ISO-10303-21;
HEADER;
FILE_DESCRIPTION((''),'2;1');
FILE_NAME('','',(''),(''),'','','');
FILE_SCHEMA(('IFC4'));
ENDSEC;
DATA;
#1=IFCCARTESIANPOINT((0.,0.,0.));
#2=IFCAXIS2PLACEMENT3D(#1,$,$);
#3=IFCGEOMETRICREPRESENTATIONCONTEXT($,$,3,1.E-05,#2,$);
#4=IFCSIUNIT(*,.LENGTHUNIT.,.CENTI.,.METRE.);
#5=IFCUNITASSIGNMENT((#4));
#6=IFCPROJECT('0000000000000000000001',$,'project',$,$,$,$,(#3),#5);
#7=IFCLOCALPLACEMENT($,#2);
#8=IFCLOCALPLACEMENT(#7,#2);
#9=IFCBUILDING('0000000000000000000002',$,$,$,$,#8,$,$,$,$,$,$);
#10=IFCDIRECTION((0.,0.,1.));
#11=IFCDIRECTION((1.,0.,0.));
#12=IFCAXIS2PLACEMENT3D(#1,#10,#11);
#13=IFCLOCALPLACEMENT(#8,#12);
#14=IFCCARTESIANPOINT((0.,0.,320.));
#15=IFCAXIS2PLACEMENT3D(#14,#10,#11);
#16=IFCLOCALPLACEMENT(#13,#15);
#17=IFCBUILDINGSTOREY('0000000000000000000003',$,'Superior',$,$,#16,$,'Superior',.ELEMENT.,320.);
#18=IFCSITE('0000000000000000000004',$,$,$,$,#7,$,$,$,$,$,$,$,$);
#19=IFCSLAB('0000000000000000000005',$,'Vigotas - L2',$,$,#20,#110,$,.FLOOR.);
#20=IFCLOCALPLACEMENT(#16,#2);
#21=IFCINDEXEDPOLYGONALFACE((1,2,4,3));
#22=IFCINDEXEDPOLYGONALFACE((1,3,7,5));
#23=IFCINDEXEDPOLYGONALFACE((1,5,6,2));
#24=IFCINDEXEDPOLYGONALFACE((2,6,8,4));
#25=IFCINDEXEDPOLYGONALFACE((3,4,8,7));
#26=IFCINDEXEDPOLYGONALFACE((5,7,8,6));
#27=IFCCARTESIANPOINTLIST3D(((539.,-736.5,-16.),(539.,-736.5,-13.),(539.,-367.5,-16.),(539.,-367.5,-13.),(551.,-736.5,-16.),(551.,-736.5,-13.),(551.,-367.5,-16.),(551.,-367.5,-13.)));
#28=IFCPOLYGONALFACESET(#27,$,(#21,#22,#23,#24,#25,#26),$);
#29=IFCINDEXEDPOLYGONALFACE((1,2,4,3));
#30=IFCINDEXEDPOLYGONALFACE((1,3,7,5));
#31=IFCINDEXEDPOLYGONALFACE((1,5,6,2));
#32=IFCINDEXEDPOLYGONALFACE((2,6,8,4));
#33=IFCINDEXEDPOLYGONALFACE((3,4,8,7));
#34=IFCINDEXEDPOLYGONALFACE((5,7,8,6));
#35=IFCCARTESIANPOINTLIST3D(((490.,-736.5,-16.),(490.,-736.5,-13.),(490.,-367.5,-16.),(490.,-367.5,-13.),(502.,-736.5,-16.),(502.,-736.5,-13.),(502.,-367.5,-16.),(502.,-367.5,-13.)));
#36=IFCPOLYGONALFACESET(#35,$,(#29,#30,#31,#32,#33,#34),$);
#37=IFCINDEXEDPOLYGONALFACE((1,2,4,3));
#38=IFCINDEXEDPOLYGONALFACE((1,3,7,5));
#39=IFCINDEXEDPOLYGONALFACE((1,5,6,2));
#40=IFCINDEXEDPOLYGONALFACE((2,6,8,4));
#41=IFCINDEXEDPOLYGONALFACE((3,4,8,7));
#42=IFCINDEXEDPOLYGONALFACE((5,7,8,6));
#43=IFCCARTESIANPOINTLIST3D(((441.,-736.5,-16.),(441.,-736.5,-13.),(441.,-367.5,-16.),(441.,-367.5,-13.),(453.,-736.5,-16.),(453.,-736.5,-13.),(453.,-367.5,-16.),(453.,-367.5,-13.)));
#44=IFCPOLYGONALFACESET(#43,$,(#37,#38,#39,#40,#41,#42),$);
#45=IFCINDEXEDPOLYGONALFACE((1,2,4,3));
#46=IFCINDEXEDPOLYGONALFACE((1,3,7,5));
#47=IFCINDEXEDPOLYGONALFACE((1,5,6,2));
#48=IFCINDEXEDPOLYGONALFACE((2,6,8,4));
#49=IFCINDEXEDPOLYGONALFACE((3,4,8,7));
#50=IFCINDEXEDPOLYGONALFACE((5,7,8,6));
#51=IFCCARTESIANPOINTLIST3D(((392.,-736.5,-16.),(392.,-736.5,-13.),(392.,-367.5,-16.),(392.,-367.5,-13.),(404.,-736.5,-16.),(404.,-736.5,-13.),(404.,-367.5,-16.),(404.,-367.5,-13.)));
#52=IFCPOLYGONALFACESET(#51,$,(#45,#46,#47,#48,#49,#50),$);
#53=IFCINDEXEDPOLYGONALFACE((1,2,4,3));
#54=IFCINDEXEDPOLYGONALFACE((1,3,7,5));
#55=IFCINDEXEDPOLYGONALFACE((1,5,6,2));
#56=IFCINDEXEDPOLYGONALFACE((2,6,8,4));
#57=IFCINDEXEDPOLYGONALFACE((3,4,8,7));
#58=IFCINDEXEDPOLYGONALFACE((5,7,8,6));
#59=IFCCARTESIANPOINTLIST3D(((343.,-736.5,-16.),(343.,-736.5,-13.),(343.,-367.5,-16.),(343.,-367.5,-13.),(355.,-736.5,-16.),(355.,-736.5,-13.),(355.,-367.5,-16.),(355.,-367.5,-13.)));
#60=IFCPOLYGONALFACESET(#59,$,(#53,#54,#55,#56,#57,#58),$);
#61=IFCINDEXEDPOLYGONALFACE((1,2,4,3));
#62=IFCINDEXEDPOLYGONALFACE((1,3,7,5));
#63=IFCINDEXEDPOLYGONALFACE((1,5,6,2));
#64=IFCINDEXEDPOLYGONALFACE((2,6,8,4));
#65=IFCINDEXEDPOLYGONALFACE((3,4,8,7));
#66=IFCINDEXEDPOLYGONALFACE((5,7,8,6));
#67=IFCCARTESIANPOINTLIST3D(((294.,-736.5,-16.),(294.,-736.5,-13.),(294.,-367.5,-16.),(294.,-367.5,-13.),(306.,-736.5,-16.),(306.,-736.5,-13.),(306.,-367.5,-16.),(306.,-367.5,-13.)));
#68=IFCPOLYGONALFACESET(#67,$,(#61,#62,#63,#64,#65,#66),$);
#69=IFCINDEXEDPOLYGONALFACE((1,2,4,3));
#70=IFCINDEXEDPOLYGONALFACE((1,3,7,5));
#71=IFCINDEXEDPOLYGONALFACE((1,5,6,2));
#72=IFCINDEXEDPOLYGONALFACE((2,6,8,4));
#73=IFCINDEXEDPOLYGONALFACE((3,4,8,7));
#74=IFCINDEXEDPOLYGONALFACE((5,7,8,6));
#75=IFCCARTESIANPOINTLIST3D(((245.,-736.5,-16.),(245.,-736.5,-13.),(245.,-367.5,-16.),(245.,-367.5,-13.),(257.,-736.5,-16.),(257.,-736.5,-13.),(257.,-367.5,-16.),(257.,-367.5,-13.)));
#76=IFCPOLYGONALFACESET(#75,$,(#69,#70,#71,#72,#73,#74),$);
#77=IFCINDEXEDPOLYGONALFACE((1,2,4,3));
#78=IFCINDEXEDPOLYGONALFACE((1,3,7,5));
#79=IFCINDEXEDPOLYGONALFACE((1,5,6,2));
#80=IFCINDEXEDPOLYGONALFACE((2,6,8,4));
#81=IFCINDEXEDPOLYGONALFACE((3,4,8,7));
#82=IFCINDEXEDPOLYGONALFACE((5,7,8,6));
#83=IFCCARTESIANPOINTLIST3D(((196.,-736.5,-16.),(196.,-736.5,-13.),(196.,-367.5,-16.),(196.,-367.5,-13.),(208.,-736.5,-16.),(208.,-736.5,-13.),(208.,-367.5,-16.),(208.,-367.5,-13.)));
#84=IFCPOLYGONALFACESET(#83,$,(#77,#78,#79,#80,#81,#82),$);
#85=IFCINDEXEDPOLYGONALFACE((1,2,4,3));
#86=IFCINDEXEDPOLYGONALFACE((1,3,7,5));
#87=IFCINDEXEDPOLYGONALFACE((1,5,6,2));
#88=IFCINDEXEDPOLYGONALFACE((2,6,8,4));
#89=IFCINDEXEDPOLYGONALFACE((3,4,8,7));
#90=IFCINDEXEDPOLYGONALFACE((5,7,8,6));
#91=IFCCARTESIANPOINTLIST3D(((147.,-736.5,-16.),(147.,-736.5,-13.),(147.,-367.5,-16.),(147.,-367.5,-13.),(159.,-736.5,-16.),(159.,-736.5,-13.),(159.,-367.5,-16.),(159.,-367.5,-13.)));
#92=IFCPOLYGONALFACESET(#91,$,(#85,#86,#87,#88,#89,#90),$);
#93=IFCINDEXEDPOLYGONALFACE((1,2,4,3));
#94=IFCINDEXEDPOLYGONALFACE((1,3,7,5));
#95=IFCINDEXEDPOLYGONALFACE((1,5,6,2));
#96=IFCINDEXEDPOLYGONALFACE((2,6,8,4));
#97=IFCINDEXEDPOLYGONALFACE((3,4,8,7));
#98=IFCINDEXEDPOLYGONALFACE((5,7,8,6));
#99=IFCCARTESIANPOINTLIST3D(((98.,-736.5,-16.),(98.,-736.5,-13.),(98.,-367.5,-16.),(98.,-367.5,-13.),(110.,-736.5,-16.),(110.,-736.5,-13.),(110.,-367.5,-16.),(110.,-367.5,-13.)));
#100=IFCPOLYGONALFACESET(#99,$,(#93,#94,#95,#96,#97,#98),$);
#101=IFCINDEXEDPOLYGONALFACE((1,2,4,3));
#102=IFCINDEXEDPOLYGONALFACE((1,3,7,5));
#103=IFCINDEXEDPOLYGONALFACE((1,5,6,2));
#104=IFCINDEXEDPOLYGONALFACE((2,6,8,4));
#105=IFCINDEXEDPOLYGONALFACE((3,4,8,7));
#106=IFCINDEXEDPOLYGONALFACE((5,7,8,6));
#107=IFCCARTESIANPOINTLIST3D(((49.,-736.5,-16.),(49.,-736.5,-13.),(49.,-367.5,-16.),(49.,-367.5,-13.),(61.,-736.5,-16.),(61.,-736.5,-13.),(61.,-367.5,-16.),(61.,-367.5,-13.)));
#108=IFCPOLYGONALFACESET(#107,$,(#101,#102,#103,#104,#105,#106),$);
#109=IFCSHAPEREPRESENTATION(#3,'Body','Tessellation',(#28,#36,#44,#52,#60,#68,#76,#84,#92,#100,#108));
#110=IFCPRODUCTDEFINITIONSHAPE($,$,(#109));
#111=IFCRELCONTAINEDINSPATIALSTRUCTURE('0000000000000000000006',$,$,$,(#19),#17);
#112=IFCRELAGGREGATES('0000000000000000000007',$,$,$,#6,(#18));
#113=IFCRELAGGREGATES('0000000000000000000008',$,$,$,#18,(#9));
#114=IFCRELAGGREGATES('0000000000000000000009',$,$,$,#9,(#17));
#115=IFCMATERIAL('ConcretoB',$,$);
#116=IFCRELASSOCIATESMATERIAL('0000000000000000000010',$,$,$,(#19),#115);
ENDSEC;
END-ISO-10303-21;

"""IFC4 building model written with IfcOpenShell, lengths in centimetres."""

from ifc_helpers import new_model, si_unit, frame, origin, origin_with_axes, place, context, project, spatial, polyline, outline, extrude, material, element, save


model = new_model("IFC4")

# Units and contexts
context_of_model = context(None, 3, precision=1e-05, world=origin())
ifc_project = project(units=[si_unit("LENGTHUNIT", "METRE", prefix="CENTI")], contexts=[context_of_model])

# Site, building, storey
site_placement = place(None, origin())
site = spatial("IfcSite", under=ifc_project, at=site_placement)
building_placement = place(site_placement, origin())
building = spatial("IfcBuilding", under=site, at=building_placement)
placement = place(building_placement, origin_with_axes())
storey_placement = place(placement, frame((0.0, 0.0, 320.0), z_axis=(0.0, 0.0, 1.0), x_axis=(1.0, 0.0, 0.0)))
storey = spatial("IfcBuildingStorey", under=building, at=storey_placement, Name="Superior", LongName="Superior", CompositionType="ELEMENT", Elevation=320.0)

# Shared definitions
ifc_material = material(Name="ConcretoB")

# Slab
slab_1_placement = place(storey_placement, frame((300.0, -552.0, -13.0), z_axis=(0.0, 0.0, 1.0), x_axis=(1.0, 0.0, 0.0)))
element("IfcSlab", 1, at=slab_1_placement, inside=storey, material=ifc_material, Name="Vigotas - L2", PredefinedType="FLOOR", context=context_of_model, shape_type="SolidModel", body=[
    extrude(outline(polyline([(6.0, 1.5), (-6.0, 1.5), (-6.0, -1.5), (6.0, -1.5), (6.0, 1.5), (6.0, 1.5)])), frame((245.0, -184.5, -1.5), z_axis=(0.0, 1.0, 0.0), x_axis=(1.0, 0.0, 0.0)), (0.0, 0.0, 1.0), 369.0),
    extrude(outline(polyline([(6.0, 1.5), (-6.0, 1.5), (-6.0, -1.5), (6.0, -1.5), (6.0, 1.5), (6.0, 1.5)])), frame((196.0, -184.5, -1.5), z_axis=(0.0, 1.0, 0.0), x_axis=(1.0, 0.0, 0.0)), (0.0, 0.0, 1.0), 369.0),
    extrude(outline(polyline([(6.0, 1.5), (-6.0, 1.5), (-6.0, -1.5), (6.0, -1.5), (6.0, 1.5), (6.0, 1.5)])), frame((147.0, -184.5, -1.5), z_axis=(0.0, 1.0, 0.0), x_axis=(1.0, 0.0, 0.0)), (0.0, 0.0, 1.0), 369.0),
    extrude(outline(polyline([(6.0, 1.5), (-6.0, 1.5), (-6.0, -1.5), (6.0, -1.5), (6.0, 1.5), (6.0, 1.5)])), frame((98.0, -184.5, -1.5), z_axis=(0.0, 1.0, 0.0), x_axis=(1.0, 0.0, 0.0)), (0.0, 0.0, 1.0), 369.0),
    extrude(outline(polyline([(6.0, 1.5), (-6.0, 1.5), (-6.0, -1.5), (6.0, -1.5), (6.0, 1.5), (6.0, 1.5)])), frame((49.0, -184.5, -1.5), z_axis=(0.0, 1.0, 0.0), x_axis=(1.0, 0.0, 0.0)), (0.0, 0.0, 1.0), 369.0),
    extrude(outline(polyline([(6.0, 1.5), (-6.0, 1.5), (-6.0, -1.5), (6.0, -1.5), (6.0, 1.5), (6.0, 1.5)])), frame((0.0, -184.5, -1.5), z_axis=(0.0, 1.0, 0.0), x_axis=(1.0, 0.0, 0.0)), (0.0, 0.0, 1.0), 369.0),
    extrude(outline(polyline([(6.0, 1.5), (-6.0, 1.5), (-6.0, -1.5), (6.0, -1.5), (6.0, 1.5), (6.0, 1.5)])), frame((-49.0, -184.5, -1.5), z_axis=(0.0, 1.0, 0.0), x_axis=(1.0, 0.0, 0.0)), (0.0, 0.0, 1.0), 369.0),
    extrude(outline(polyline([(6.0, 1.5), (-6.0, 1.5), (-6.0, -1.5), (6.0, -1.5), (6.0, 1.5), (6.0, 1.5)])), frame((-98.0, -184.5, -1.5), z_axis=(0.0, 1.0, 0.0), x_axis=(1.0, 0.0, 0.0)), (0.0, 0.0, 1.0), 369.0),
    extrude(outline(polyline([(6.0, 1.5), (-6.0, 1.5), (-6.0, -1.5), (6.0, -1.5), (6.0, 1.5), (6.0, 1.5)])), frame((-147.0, -184.5, -1.5), z_axis=(0.0, 1.0, 0.0), x_axis=(1.0, 0.0, 0.0)), (0.0, 0.0, 1.0), 369.0),
    extrude(outline(polyline([(6.0, 1.5), (-6.0, 1.5), (-6.0, -1.5), (6.0, -1.5), (6.0, 1.5), (6.0, 1.5)])), frame((-196.0, -184.5, -1.5), z_axis=(0.0, 1.0, 0.0), x_axis=(1.0, 0.0, 0.0)), (0.0, 0.0, 1.0), 369.0),
    extrude(outline(polyline([(6.0, 1.5), (-6.0, 1.5), (-6.0, -1.5), (6.0, -1.5), (6.0, 1.5), (6.0, 1.5)])), frame((-245.0, -184.5, -1.5), z_axis=(0.0, 1.0, 0.0), x_axis=(1.0, 0.0, 0.0)), (0.0, 0.0, 1.0), 369.0),
])

save(model, "model.ifc")
